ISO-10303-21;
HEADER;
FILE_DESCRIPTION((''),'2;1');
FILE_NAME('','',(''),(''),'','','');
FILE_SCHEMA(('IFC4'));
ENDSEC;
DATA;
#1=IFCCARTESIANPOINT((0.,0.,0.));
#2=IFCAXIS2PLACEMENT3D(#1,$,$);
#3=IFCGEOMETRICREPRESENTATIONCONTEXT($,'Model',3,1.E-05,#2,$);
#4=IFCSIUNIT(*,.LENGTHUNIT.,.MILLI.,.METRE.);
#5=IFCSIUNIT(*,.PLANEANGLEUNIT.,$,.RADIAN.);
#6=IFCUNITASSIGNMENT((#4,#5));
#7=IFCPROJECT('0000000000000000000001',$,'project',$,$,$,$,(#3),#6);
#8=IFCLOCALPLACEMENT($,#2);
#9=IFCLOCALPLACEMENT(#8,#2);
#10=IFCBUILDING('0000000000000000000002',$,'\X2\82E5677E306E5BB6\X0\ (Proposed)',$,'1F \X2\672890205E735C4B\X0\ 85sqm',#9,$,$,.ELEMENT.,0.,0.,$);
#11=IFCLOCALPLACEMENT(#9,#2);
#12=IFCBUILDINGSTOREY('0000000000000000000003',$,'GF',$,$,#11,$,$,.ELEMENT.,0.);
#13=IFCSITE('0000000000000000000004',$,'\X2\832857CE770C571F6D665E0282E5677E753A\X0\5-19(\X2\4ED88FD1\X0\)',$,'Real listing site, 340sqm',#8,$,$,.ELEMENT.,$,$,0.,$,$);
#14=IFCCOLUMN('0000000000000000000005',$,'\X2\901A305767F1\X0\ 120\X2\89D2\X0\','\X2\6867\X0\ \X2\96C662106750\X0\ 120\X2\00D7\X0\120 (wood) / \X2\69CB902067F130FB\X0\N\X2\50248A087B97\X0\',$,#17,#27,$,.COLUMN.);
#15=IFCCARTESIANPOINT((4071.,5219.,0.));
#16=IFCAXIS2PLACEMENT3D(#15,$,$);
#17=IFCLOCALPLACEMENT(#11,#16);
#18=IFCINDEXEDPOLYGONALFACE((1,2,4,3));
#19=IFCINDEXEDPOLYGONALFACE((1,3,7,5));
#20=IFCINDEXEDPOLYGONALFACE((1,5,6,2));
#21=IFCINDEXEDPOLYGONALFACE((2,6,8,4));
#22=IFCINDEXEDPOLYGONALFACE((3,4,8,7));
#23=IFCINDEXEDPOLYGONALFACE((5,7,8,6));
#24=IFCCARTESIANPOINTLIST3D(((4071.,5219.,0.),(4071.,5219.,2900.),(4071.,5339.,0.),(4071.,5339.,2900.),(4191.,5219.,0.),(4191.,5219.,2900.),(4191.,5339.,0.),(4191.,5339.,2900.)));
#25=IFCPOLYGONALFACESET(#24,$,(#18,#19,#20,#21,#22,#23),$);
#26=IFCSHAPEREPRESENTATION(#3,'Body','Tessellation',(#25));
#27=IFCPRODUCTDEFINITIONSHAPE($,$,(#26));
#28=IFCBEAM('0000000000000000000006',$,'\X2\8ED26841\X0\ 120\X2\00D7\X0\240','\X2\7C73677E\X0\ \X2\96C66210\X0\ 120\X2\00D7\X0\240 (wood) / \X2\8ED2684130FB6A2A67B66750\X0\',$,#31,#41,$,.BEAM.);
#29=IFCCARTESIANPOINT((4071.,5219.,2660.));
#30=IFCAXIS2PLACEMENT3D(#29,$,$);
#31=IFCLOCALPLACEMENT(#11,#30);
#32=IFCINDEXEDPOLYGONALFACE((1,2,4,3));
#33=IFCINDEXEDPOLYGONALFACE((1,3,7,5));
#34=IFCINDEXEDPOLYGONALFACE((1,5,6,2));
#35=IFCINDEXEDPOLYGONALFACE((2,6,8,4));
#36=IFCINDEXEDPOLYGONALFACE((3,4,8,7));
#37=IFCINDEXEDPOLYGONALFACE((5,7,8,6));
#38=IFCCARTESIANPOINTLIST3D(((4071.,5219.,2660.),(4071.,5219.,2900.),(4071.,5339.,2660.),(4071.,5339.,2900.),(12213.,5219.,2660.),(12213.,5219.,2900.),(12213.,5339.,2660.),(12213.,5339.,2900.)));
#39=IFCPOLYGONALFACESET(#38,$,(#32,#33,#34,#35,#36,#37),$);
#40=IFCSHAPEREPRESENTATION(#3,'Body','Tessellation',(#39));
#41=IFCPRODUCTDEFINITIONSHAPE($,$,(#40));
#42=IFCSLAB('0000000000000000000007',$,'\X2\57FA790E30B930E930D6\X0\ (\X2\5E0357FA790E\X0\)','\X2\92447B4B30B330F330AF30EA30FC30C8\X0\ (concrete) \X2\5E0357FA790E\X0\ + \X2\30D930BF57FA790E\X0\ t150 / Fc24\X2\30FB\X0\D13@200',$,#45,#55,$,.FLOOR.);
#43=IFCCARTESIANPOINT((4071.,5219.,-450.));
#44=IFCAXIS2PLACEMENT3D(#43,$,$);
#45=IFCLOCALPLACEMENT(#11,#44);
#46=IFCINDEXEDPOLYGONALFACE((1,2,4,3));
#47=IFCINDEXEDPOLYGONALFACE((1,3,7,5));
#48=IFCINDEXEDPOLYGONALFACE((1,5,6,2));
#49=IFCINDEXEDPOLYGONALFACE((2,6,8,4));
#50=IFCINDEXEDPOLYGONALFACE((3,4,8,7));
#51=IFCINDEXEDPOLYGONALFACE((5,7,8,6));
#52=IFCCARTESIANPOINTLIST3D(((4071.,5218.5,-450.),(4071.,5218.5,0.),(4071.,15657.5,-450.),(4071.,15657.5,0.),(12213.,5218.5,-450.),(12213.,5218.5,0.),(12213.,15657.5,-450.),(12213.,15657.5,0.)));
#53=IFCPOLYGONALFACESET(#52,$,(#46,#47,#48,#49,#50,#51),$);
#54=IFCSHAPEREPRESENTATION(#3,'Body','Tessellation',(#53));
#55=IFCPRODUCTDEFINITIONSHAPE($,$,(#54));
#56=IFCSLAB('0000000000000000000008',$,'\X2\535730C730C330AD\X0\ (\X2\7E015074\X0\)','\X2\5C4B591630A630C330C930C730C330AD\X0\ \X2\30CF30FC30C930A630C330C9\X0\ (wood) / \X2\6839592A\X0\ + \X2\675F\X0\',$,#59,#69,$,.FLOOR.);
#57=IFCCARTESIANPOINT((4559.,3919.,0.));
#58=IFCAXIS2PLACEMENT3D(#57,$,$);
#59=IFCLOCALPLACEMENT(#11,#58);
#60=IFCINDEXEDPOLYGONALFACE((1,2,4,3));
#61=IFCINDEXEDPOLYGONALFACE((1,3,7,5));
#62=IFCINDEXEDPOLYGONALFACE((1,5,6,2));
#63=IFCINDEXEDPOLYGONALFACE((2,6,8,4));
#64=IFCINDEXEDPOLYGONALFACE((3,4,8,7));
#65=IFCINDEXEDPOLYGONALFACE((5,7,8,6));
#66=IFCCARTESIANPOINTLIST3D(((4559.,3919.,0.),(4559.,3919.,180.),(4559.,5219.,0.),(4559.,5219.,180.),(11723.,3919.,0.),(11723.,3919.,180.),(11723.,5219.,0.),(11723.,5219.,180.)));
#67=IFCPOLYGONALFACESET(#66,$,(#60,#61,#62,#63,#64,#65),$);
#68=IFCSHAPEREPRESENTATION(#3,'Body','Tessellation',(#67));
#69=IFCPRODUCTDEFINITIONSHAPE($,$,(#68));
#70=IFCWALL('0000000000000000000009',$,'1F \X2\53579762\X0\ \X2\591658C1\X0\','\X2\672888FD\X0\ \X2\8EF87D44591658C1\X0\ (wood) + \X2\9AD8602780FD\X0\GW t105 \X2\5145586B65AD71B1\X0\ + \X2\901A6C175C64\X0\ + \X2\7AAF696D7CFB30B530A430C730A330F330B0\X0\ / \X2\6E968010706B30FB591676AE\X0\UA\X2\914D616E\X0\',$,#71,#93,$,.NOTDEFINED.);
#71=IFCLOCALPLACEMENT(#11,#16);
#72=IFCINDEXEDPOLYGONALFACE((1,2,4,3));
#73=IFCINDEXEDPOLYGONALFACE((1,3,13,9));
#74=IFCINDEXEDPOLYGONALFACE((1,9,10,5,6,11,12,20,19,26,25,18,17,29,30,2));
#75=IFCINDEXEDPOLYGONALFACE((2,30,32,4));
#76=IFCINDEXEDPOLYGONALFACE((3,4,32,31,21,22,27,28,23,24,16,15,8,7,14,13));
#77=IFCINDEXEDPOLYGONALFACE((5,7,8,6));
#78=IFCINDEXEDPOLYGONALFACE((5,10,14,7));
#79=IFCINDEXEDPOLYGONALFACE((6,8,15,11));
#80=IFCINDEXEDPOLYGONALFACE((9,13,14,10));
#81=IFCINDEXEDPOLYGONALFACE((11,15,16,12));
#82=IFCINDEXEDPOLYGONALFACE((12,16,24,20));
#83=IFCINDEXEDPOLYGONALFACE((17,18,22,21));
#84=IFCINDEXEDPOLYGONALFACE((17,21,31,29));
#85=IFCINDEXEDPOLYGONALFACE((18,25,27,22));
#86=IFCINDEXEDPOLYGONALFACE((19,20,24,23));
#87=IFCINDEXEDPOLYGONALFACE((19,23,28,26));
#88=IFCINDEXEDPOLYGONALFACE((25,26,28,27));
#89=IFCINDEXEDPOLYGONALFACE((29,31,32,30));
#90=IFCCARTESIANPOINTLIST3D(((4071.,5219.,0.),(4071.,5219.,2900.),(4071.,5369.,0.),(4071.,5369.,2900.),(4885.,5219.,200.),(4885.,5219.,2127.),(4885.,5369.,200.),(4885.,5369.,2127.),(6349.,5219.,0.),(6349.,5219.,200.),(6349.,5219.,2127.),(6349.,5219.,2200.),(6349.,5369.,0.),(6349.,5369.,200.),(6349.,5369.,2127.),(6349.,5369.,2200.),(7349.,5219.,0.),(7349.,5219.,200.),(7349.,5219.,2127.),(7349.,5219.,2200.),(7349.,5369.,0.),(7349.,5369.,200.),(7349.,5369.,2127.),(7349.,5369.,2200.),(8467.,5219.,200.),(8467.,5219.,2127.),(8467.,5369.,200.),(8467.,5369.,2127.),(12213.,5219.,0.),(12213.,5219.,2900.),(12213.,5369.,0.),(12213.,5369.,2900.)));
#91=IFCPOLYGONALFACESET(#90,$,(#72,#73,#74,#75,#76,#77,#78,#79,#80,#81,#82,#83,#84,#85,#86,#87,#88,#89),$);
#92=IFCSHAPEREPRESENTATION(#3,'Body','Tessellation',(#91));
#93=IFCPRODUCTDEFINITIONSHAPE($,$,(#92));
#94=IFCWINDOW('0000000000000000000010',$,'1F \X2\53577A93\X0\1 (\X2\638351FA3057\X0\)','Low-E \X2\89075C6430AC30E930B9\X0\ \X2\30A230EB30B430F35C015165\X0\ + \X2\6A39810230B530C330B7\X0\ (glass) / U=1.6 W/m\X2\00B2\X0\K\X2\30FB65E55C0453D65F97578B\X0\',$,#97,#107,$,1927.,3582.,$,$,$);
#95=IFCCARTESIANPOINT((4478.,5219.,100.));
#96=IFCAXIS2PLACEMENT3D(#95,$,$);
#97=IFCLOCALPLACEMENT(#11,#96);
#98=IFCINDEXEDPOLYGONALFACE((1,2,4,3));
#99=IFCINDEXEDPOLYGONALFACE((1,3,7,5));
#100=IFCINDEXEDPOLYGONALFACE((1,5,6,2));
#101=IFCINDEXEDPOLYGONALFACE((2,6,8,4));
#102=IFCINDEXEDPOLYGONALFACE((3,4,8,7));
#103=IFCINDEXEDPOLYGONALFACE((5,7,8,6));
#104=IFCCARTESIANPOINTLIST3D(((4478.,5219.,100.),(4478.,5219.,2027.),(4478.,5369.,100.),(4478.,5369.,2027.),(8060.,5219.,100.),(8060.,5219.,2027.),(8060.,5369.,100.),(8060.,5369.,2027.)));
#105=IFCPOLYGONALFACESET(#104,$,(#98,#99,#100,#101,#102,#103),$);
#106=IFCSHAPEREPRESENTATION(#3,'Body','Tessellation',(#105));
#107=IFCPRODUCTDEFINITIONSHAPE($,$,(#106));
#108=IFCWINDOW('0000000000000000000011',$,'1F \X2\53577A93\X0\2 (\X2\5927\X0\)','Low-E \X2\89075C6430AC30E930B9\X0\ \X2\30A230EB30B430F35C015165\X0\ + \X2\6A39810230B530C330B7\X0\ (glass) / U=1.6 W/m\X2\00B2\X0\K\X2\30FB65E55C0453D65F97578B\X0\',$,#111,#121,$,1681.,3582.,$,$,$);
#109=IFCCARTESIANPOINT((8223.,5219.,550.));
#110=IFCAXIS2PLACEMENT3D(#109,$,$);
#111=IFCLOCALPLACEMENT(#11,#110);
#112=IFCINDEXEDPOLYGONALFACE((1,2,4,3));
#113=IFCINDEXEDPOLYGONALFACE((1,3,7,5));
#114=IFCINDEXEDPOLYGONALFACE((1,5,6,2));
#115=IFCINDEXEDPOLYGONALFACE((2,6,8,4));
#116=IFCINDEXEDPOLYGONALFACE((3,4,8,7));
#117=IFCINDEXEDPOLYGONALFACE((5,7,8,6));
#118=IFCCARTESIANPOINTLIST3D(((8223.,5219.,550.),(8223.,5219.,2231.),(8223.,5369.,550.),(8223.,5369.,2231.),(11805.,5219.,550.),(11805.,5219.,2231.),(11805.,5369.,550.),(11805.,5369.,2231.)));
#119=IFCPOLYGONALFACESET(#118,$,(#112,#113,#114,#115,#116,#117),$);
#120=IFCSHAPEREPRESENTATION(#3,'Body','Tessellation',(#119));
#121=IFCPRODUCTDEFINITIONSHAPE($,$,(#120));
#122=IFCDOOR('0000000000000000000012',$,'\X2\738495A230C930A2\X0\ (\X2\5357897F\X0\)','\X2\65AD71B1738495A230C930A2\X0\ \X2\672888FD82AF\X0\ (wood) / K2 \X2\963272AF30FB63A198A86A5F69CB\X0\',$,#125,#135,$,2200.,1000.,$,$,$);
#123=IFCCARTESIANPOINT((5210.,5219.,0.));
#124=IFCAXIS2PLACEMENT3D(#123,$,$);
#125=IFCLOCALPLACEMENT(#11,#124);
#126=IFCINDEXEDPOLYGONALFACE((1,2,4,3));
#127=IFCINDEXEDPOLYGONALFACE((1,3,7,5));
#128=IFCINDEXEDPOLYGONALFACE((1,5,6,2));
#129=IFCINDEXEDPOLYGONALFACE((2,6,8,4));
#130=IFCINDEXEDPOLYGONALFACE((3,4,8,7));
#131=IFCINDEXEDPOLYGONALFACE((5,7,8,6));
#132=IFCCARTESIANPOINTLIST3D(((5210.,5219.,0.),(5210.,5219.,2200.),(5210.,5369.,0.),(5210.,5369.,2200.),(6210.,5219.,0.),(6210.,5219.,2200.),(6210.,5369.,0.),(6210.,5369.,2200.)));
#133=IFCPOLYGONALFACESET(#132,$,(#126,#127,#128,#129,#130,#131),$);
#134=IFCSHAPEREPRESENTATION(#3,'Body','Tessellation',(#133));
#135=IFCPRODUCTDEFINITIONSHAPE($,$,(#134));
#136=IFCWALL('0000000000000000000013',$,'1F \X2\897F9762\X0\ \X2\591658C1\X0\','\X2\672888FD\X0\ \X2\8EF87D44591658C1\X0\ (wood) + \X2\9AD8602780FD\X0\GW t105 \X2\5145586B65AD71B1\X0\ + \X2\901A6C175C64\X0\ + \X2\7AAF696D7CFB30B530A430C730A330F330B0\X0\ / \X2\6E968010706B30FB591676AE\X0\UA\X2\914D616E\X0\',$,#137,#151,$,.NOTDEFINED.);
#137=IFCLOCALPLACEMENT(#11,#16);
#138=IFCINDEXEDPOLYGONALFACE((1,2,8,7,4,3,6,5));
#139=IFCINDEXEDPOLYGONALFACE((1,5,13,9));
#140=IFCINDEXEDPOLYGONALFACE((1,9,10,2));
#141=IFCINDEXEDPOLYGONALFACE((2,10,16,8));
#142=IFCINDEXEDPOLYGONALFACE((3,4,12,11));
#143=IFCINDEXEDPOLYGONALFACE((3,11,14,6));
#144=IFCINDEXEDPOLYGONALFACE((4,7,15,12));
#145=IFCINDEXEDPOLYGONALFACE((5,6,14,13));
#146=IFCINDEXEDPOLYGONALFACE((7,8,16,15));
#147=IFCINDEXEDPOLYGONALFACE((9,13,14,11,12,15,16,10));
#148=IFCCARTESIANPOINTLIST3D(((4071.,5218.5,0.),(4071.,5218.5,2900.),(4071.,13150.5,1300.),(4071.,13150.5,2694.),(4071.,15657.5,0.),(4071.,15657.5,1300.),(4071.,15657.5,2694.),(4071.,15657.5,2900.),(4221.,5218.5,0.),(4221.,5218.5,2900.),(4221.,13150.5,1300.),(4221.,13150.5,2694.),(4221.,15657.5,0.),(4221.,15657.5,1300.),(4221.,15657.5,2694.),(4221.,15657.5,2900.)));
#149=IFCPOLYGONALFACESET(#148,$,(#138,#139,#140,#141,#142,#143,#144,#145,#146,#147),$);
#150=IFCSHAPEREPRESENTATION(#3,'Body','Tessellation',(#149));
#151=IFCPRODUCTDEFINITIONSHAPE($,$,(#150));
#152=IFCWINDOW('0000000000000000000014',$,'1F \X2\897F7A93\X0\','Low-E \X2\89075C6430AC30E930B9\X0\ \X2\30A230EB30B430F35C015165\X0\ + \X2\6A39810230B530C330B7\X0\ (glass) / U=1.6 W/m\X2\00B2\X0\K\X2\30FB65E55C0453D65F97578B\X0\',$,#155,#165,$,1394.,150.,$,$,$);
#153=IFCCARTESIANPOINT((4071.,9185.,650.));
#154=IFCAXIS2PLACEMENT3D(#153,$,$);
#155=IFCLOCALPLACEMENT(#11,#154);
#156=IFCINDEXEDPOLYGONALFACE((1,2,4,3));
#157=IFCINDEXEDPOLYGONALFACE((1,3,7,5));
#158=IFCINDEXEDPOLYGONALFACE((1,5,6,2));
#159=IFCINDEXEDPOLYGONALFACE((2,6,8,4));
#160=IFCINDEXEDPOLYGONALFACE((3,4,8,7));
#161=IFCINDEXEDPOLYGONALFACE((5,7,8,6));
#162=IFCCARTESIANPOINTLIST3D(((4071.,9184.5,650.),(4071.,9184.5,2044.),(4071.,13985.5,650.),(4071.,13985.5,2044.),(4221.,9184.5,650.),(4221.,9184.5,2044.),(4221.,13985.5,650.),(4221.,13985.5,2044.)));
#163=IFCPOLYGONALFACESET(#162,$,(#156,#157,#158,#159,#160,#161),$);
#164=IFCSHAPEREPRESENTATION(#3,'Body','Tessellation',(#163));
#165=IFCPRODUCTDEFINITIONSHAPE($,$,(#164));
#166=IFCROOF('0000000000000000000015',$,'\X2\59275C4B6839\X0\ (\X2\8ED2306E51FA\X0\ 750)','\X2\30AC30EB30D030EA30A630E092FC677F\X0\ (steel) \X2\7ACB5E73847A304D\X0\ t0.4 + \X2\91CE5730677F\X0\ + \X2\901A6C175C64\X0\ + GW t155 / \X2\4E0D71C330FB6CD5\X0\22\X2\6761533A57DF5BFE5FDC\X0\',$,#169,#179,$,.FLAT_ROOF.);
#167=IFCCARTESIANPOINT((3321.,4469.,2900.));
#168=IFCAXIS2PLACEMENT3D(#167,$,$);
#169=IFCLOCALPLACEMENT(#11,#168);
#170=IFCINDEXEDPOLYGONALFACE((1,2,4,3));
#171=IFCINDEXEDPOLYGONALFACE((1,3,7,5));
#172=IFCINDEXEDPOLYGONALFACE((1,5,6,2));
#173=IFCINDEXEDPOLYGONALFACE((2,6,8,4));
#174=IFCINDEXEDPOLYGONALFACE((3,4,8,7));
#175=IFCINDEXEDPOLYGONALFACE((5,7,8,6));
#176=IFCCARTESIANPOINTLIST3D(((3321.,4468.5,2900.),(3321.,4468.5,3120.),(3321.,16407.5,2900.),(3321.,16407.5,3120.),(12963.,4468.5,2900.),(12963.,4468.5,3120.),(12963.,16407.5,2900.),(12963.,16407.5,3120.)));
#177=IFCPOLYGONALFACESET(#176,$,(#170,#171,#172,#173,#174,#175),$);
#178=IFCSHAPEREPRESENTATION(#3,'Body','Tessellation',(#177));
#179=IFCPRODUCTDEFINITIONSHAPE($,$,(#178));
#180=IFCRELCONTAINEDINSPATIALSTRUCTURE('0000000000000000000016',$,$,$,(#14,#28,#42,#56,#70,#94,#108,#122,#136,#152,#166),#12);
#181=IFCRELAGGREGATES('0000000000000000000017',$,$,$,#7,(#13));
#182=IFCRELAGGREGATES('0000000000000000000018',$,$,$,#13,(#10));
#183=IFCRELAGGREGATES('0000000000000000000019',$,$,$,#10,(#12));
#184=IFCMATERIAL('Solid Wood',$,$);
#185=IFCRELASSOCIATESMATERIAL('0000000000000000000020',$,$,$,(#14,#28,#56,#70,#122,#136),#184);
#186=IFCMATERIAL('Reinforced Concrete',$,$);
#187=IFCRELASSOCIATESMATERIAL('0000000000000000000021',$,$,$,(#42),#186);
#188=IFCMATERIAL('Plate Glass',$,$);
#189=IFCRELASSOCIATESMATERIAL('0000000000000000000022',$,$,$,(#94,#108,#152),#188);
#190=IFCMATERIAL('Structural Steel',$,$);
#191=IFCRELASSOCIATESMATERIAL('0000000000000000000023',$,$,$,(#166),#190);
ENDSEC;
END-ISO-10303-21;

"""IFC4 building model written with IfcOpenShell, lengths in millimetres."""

from ifc_helpers import new_model, si_unit, frame, frame_2d, origin, place, context, project, spatial, rectangle, extrude, material, element, fill, save


model = new_model("IFC4")

# Units and contexts
model_context = context("Model", 3, precision=1e-05, world=origin())
ifc_project = project(units=[si_unit("LENGTHUNIT", "METRE", prefix="MILLI"), si_unit("PLANEANGLEUNIT", "RADIAN")], contexts=[model_context])

# Site, building, storey
site_placement = place(None, origin())
site = spatial("IfcSite", under=ifc_project, at=site_placement, Name="茨城県土浦市若松町5-19(付近)", ObjectType="Real listing site, 340sqm", CompositionType="ELEMENT", RefElevation=0.0)
building_placement = place(site_placement, origin())
building = spatial("IfcBuilding", under=site, at=building_placement, Name="若松の家 (Proposed)", ObjectType="1F 木造平屋 85sqm", CompositionType="ELEMENT", ElevationOfRefHeight=0.0, ElevationOfTerrain=0.0)
storey_placement = place(building_placement, origin())
storey = spatial("IfcBuildingStorey", under=building, at=storey_placement, Name="GF", CompositionType="ELEMENT", Elevation=0.0)

# Column
ifc_material_1 = material(Name="Solid Wood")
column_1_placement = place(storey_placement, frame((4071.0, 5219.0, 0.0)))
element("IfcColumn", 1, at=column_1_placement, inside=storey, material=ifc_material_1, Name="通し柱 120角", Description="桧 集成材 120×120 (wood) / 構造柱・N値計算", PredefinedType="COLUMN", context=model_context, shape_type="SweptSolid", body=[
    extrude(rectangle(XDim=120.0, YDim=120.0, at=frame_2d((60.0, 60.0))), frame((4071.0, 5219.0, 0.0)), (0.0, 0.0, 1.0), 2900.0),
])

# Beam
beam_1_placement = place(storey_placement, frame((4071.0, 5219.0, 2660.0)))
element("IfcBeam", 2, at=beam_1_placement, inside=storey, material=ifc_material_1, Name="軒桁 120×240", Description="米松 集成 120×240 (wood) / 軒桁・横架材", PredefinedType="BEAM", context=model_context, shape_type="SweptSolid", body=[
    extrude(rectangle(XDim=8142.0, YDim=120.0, at=frame_2d((4071.0, 60.0))), frame((4071.0, 5219.0, 2660.0)), (0.0, 0.0, 1.0), 240.0),
])

# Slabs
ifc_material_2 = material(Name="Reinforced Concrete")
slab_1_placement = place(storey_placement, frame((4071.0, 5219.0, -450.0)))
element("IfcSlab", 3, at=slab_1_placement, inside=storey, material=ifc_material_2, Name="基礎スラブ (布基礎)", Description="鉄筋コンクリート (concrete) 布基礎 + ベタ基礎 t150 / Fc24・D13@200", PredefinedType="FLOOR", context=model_context, shape_type="SweptSolid", body=[
    extrude(rectangle(XDim=8142.0, YDim=10439.0, at=frame_2d((4071.0, 5219.0))), frame((4071.0, 5219.0, -450.0)), (0.0, 0.0, 1.0), 450.0),
])
slab_2_placement = place(storey_placement, frame((4559.0, 3919.0, 0.0)))
element("IfcSlab", 4, at=slab_2_placement, inside=storey, material=ifc_material_1, Name="南デッキ (縁側)", Description="屋外ウッドデッキ ハードウッド (wood) / 根太 + 束", PredefinedType="FLOOR", context=model_context, shape_type="SweptSolid", body=[
    extrude(rectangle(XDim=7164.0, YDim=1300.0, at=frame_2d((3582.0, 650.0))), frame((4559.0, 3919.0, 0.0)), (0.0, 0.0, 1.0), 180.0),
])

# Wall, openings, windows, door
wall_1_placement = place(storey_placement, frame((4071.0, 5219.0, 0.0)))
wall_1 = element("IfcWall", 5, at=wall_1_placement, inside=storey, material=ifc_material_1, Name="1F 南面 外壁", Description="木製 軸組外壁 (wood) + 高性能GW t105 充填断熱 + 通気層 + 窯業系サイディング / 準耐火・外皮UA配慮", PredefinedType="NOTDEFINED", context=model_context, shape_type="SweptSolid", body=[
    extrude(rectangle(XDim=8142.0, YDim=150.0, at=frame_2d((4071.0, 75.0))), frame((4071.0, 5219.0, 0.0)), (0.0, 0.0, 1.0), 2900.0),
])
opening_1_placement = place(storey_placement, frame((4478.0, 5219.0, 100.0)))
opening_1 = element("IfcOpeningElement", 6, at=opening_1_placement, cuts=wall_1, PredefinedType="NOTDEFINED", context=model_context, shape_type="SweptSolid", body=[
    extrude(rectangle(XDim=3582.0, YDim=150.0, at=frame_2d((1791.0, 75.0))), frame((4478.0, 5219.0, 100.0)), (0.0, 0.0, 1.0), 1927.0),
])
opening_2_placement = place(storey_placement, frame((8223.0, 5219.0, 550.0)))
opening_2 = element("IfcOpeningElement", 7, at=opening_2_placement, cuts=wall_1, PredefinedType="NOTDEFINED", context=model_context, shape_type="SweptSolid", body=[
    extrude(rectangle(XDim=3582.0, YDim=150.0, at=frame_2d((1791.0, 75.0))), frame((8223.0, 5219.0, 550.0)), (0.0, 0.0, 1.0), 1681.0),
])
opening_3_placement = place(storey_placement, frame((5210.0, 5219.0, 0.0)))
opening_3 = element("IfcOpeningElement", 8, at=opening_3_placement, cuts=wall_1, PredefinedType="NOTDEFINED", context=model_context, shape_type="SweptSolid", body=[
    extrude(rectangle(XDim=1000.0, YDim=150.0, at=frame_2d((500.0, 75.0))), frame((5210.0, 5219.0, 0.0)), (0.0, 0.0, 1.0), 2200.0),
])
ifc_material_3 = material(Name="Plate Glass")
window_1_placement = place(storey_placement, frame((4478.0, 5219.0, 100.0)))
window_1 = element("IfcWindow", 9, at=window_1_placement, inside=storey, material=ifc_material_3, Name="1F 南窓1 (掃出し)", Description="Low-E 複層ガラス アルゴン封入 + 樹脂サッシ (glass) / U=1.6 W/m²K・日射取得型", OverallHeight=1927.0, OverallWidth=3582.0, context=model_context, shape_type="SweptSolid", body=[
    extrude(rectangle(XDim=3582.0, YDim=150.0, at=frame_2d((1791.0, 75.0))), frame((4478.0, 5219.0, 100.0)), (0.0, 0.0, 1.0), 1927.0),
])
fill(opening_1, window_1)
window_2_placement = place(storey_placement, frame((8223.0, 5219.0, 550.0)))
window_2 = element("IfcWindow", 10, at=window_2_placement, inside=storey, material=ifc_material_3, Name="1F 南窓2 (大)", Description="Low-E 複層ガラス アルゴン封入 + 樹脂サッシ (glass) / U=1.6 W/m²K・日射取得型", OverallHeight=1681.0, OverallWidth=3582.0, context=model_context, shape_type="SweptSolid", body=[
    extrude(rectangle(XDim=3582.0, YDim=150.0, at=frame_2d((1791.0, 75.0))), frame((8223.0, 5219.0, 550.0)), (0.0, 0.0, 1.0), 1681.0),
])
fill(opening_2, window_2)
door_placement = place(storey_placement, frame((5210.0, 5219.0, 0.0)))
door = element("IfcDoor", 11, at=door_placement, inside=storey, material=ifc_material_1, Name="玄関ドア (南西)", Description="断熱玄関ドア 木製芯 (wood) / K2 防犯・採風機構", OverallHeight=2200.0, OverallWidth=1000.0, context=model_context, shape_type="SweptSolid", body=[
    extrude(rectangle(XDim=1000.0, YDim=150.0, at=frame_2d((500.0, 75.0))), frame((5210.0, 5219.0, 0.0)), (0.0, 0.0, 1.0), 2200.0),
])
fill(opening_3, door)

# Wall, opening, window
wall_2_placement = place(storey_placement, frame((4071.0, 5219.0, 0.0)))
wall_2 = element("IfcWall", 12, at=wall_2_placement, inside=storey, material=ifc_material_1, Name="1F 西面 外壁", Description="木製 軸組外壁 (wood) + 高性能GW t105 充填断熱 + 通気層 + 窯業系サイディング / 準耐火・外皮UA配慮", PredefinedType="NOTDEFINED", context=model_context, shape_type="SweptSolid", body=[
    extrude(rectangle(XDim=150.0, YDim=10439.0, at=frame_2d((75.0, 5219.0))), frame((4071.0, 5219.0, 0.0)), (0.0, 0.0, 1.0), 2900.0),
])
opening_4_placement = place(storey_placement, frame((4071.0, 9185.0, 650.0)))
opening_4 = element("IfcOpeningElement", 13, at=opening_4_placement, cuts=wall_2, PredefinedType="NOTDEFINED", context=model_context, shape_type="SweptSolid", body=[
    extrude(rectangle(XDim=150.0, YDim=4801.0, at=frame_2d((75.0, 2400.0))), frame((4071.0, 9185.0, 650.0)), (0.0, 0.0, 1.0), 1394.0),
])
window_3_placement = place(storey_placement, frame((4071.0, 9185.0, 650.0)))
window_3 = element("IfcWindow", 14, at=window_3_placement, inside=storey, material=ifc_material_3, Name="1F 西窓", Description="Low-E 複層ガラス アルゴン封入 + 樹脂サッシ (glass) / U=1.6 W/m²K・日射取得型", OverallHeight=1394.0, OverallWidth=150.0, context=model_context, shape_type="SweptSolid", body=[
    extrude(rectangle(XDim=150.0, YDim=4801.0, at=frame_2d((75.0, 2400.0))), frame((4071.0, 9185.0, 650.0)), (0.0, 0.0, 1.0), 1394.0),
])
fill(opening_4, window_3)

# Roof
ifc_material_4 = material(Name="Structural Steel")
roof_placement = place(storey_placement, frame((3321.0, 4469.0, 2900.0)))
element("IfcRoof", 15, at=roof_placement, inside=storey, material=ifc_material_4, Name="大屋根 (軒の出 750)", Description="ガルバリウム鋼板 (steel) 立平葺き t0.4 + 野地板 + 通気層 + GW t155 / 不燃・法22条区域対応", PredefinedType="FLAT_ROOF", context=model_context, shape_type="SweptSolid", body=[
    extrude(rectangle(XDim=9642.0, YDim=11939.0, at=frame_2d((4821.0, 5969.0))), frame((3321.0, 4469.0, 2900.0)), (0.0, 0.0, 1.0), 220.0),
])

save(model, "model.ifc")
